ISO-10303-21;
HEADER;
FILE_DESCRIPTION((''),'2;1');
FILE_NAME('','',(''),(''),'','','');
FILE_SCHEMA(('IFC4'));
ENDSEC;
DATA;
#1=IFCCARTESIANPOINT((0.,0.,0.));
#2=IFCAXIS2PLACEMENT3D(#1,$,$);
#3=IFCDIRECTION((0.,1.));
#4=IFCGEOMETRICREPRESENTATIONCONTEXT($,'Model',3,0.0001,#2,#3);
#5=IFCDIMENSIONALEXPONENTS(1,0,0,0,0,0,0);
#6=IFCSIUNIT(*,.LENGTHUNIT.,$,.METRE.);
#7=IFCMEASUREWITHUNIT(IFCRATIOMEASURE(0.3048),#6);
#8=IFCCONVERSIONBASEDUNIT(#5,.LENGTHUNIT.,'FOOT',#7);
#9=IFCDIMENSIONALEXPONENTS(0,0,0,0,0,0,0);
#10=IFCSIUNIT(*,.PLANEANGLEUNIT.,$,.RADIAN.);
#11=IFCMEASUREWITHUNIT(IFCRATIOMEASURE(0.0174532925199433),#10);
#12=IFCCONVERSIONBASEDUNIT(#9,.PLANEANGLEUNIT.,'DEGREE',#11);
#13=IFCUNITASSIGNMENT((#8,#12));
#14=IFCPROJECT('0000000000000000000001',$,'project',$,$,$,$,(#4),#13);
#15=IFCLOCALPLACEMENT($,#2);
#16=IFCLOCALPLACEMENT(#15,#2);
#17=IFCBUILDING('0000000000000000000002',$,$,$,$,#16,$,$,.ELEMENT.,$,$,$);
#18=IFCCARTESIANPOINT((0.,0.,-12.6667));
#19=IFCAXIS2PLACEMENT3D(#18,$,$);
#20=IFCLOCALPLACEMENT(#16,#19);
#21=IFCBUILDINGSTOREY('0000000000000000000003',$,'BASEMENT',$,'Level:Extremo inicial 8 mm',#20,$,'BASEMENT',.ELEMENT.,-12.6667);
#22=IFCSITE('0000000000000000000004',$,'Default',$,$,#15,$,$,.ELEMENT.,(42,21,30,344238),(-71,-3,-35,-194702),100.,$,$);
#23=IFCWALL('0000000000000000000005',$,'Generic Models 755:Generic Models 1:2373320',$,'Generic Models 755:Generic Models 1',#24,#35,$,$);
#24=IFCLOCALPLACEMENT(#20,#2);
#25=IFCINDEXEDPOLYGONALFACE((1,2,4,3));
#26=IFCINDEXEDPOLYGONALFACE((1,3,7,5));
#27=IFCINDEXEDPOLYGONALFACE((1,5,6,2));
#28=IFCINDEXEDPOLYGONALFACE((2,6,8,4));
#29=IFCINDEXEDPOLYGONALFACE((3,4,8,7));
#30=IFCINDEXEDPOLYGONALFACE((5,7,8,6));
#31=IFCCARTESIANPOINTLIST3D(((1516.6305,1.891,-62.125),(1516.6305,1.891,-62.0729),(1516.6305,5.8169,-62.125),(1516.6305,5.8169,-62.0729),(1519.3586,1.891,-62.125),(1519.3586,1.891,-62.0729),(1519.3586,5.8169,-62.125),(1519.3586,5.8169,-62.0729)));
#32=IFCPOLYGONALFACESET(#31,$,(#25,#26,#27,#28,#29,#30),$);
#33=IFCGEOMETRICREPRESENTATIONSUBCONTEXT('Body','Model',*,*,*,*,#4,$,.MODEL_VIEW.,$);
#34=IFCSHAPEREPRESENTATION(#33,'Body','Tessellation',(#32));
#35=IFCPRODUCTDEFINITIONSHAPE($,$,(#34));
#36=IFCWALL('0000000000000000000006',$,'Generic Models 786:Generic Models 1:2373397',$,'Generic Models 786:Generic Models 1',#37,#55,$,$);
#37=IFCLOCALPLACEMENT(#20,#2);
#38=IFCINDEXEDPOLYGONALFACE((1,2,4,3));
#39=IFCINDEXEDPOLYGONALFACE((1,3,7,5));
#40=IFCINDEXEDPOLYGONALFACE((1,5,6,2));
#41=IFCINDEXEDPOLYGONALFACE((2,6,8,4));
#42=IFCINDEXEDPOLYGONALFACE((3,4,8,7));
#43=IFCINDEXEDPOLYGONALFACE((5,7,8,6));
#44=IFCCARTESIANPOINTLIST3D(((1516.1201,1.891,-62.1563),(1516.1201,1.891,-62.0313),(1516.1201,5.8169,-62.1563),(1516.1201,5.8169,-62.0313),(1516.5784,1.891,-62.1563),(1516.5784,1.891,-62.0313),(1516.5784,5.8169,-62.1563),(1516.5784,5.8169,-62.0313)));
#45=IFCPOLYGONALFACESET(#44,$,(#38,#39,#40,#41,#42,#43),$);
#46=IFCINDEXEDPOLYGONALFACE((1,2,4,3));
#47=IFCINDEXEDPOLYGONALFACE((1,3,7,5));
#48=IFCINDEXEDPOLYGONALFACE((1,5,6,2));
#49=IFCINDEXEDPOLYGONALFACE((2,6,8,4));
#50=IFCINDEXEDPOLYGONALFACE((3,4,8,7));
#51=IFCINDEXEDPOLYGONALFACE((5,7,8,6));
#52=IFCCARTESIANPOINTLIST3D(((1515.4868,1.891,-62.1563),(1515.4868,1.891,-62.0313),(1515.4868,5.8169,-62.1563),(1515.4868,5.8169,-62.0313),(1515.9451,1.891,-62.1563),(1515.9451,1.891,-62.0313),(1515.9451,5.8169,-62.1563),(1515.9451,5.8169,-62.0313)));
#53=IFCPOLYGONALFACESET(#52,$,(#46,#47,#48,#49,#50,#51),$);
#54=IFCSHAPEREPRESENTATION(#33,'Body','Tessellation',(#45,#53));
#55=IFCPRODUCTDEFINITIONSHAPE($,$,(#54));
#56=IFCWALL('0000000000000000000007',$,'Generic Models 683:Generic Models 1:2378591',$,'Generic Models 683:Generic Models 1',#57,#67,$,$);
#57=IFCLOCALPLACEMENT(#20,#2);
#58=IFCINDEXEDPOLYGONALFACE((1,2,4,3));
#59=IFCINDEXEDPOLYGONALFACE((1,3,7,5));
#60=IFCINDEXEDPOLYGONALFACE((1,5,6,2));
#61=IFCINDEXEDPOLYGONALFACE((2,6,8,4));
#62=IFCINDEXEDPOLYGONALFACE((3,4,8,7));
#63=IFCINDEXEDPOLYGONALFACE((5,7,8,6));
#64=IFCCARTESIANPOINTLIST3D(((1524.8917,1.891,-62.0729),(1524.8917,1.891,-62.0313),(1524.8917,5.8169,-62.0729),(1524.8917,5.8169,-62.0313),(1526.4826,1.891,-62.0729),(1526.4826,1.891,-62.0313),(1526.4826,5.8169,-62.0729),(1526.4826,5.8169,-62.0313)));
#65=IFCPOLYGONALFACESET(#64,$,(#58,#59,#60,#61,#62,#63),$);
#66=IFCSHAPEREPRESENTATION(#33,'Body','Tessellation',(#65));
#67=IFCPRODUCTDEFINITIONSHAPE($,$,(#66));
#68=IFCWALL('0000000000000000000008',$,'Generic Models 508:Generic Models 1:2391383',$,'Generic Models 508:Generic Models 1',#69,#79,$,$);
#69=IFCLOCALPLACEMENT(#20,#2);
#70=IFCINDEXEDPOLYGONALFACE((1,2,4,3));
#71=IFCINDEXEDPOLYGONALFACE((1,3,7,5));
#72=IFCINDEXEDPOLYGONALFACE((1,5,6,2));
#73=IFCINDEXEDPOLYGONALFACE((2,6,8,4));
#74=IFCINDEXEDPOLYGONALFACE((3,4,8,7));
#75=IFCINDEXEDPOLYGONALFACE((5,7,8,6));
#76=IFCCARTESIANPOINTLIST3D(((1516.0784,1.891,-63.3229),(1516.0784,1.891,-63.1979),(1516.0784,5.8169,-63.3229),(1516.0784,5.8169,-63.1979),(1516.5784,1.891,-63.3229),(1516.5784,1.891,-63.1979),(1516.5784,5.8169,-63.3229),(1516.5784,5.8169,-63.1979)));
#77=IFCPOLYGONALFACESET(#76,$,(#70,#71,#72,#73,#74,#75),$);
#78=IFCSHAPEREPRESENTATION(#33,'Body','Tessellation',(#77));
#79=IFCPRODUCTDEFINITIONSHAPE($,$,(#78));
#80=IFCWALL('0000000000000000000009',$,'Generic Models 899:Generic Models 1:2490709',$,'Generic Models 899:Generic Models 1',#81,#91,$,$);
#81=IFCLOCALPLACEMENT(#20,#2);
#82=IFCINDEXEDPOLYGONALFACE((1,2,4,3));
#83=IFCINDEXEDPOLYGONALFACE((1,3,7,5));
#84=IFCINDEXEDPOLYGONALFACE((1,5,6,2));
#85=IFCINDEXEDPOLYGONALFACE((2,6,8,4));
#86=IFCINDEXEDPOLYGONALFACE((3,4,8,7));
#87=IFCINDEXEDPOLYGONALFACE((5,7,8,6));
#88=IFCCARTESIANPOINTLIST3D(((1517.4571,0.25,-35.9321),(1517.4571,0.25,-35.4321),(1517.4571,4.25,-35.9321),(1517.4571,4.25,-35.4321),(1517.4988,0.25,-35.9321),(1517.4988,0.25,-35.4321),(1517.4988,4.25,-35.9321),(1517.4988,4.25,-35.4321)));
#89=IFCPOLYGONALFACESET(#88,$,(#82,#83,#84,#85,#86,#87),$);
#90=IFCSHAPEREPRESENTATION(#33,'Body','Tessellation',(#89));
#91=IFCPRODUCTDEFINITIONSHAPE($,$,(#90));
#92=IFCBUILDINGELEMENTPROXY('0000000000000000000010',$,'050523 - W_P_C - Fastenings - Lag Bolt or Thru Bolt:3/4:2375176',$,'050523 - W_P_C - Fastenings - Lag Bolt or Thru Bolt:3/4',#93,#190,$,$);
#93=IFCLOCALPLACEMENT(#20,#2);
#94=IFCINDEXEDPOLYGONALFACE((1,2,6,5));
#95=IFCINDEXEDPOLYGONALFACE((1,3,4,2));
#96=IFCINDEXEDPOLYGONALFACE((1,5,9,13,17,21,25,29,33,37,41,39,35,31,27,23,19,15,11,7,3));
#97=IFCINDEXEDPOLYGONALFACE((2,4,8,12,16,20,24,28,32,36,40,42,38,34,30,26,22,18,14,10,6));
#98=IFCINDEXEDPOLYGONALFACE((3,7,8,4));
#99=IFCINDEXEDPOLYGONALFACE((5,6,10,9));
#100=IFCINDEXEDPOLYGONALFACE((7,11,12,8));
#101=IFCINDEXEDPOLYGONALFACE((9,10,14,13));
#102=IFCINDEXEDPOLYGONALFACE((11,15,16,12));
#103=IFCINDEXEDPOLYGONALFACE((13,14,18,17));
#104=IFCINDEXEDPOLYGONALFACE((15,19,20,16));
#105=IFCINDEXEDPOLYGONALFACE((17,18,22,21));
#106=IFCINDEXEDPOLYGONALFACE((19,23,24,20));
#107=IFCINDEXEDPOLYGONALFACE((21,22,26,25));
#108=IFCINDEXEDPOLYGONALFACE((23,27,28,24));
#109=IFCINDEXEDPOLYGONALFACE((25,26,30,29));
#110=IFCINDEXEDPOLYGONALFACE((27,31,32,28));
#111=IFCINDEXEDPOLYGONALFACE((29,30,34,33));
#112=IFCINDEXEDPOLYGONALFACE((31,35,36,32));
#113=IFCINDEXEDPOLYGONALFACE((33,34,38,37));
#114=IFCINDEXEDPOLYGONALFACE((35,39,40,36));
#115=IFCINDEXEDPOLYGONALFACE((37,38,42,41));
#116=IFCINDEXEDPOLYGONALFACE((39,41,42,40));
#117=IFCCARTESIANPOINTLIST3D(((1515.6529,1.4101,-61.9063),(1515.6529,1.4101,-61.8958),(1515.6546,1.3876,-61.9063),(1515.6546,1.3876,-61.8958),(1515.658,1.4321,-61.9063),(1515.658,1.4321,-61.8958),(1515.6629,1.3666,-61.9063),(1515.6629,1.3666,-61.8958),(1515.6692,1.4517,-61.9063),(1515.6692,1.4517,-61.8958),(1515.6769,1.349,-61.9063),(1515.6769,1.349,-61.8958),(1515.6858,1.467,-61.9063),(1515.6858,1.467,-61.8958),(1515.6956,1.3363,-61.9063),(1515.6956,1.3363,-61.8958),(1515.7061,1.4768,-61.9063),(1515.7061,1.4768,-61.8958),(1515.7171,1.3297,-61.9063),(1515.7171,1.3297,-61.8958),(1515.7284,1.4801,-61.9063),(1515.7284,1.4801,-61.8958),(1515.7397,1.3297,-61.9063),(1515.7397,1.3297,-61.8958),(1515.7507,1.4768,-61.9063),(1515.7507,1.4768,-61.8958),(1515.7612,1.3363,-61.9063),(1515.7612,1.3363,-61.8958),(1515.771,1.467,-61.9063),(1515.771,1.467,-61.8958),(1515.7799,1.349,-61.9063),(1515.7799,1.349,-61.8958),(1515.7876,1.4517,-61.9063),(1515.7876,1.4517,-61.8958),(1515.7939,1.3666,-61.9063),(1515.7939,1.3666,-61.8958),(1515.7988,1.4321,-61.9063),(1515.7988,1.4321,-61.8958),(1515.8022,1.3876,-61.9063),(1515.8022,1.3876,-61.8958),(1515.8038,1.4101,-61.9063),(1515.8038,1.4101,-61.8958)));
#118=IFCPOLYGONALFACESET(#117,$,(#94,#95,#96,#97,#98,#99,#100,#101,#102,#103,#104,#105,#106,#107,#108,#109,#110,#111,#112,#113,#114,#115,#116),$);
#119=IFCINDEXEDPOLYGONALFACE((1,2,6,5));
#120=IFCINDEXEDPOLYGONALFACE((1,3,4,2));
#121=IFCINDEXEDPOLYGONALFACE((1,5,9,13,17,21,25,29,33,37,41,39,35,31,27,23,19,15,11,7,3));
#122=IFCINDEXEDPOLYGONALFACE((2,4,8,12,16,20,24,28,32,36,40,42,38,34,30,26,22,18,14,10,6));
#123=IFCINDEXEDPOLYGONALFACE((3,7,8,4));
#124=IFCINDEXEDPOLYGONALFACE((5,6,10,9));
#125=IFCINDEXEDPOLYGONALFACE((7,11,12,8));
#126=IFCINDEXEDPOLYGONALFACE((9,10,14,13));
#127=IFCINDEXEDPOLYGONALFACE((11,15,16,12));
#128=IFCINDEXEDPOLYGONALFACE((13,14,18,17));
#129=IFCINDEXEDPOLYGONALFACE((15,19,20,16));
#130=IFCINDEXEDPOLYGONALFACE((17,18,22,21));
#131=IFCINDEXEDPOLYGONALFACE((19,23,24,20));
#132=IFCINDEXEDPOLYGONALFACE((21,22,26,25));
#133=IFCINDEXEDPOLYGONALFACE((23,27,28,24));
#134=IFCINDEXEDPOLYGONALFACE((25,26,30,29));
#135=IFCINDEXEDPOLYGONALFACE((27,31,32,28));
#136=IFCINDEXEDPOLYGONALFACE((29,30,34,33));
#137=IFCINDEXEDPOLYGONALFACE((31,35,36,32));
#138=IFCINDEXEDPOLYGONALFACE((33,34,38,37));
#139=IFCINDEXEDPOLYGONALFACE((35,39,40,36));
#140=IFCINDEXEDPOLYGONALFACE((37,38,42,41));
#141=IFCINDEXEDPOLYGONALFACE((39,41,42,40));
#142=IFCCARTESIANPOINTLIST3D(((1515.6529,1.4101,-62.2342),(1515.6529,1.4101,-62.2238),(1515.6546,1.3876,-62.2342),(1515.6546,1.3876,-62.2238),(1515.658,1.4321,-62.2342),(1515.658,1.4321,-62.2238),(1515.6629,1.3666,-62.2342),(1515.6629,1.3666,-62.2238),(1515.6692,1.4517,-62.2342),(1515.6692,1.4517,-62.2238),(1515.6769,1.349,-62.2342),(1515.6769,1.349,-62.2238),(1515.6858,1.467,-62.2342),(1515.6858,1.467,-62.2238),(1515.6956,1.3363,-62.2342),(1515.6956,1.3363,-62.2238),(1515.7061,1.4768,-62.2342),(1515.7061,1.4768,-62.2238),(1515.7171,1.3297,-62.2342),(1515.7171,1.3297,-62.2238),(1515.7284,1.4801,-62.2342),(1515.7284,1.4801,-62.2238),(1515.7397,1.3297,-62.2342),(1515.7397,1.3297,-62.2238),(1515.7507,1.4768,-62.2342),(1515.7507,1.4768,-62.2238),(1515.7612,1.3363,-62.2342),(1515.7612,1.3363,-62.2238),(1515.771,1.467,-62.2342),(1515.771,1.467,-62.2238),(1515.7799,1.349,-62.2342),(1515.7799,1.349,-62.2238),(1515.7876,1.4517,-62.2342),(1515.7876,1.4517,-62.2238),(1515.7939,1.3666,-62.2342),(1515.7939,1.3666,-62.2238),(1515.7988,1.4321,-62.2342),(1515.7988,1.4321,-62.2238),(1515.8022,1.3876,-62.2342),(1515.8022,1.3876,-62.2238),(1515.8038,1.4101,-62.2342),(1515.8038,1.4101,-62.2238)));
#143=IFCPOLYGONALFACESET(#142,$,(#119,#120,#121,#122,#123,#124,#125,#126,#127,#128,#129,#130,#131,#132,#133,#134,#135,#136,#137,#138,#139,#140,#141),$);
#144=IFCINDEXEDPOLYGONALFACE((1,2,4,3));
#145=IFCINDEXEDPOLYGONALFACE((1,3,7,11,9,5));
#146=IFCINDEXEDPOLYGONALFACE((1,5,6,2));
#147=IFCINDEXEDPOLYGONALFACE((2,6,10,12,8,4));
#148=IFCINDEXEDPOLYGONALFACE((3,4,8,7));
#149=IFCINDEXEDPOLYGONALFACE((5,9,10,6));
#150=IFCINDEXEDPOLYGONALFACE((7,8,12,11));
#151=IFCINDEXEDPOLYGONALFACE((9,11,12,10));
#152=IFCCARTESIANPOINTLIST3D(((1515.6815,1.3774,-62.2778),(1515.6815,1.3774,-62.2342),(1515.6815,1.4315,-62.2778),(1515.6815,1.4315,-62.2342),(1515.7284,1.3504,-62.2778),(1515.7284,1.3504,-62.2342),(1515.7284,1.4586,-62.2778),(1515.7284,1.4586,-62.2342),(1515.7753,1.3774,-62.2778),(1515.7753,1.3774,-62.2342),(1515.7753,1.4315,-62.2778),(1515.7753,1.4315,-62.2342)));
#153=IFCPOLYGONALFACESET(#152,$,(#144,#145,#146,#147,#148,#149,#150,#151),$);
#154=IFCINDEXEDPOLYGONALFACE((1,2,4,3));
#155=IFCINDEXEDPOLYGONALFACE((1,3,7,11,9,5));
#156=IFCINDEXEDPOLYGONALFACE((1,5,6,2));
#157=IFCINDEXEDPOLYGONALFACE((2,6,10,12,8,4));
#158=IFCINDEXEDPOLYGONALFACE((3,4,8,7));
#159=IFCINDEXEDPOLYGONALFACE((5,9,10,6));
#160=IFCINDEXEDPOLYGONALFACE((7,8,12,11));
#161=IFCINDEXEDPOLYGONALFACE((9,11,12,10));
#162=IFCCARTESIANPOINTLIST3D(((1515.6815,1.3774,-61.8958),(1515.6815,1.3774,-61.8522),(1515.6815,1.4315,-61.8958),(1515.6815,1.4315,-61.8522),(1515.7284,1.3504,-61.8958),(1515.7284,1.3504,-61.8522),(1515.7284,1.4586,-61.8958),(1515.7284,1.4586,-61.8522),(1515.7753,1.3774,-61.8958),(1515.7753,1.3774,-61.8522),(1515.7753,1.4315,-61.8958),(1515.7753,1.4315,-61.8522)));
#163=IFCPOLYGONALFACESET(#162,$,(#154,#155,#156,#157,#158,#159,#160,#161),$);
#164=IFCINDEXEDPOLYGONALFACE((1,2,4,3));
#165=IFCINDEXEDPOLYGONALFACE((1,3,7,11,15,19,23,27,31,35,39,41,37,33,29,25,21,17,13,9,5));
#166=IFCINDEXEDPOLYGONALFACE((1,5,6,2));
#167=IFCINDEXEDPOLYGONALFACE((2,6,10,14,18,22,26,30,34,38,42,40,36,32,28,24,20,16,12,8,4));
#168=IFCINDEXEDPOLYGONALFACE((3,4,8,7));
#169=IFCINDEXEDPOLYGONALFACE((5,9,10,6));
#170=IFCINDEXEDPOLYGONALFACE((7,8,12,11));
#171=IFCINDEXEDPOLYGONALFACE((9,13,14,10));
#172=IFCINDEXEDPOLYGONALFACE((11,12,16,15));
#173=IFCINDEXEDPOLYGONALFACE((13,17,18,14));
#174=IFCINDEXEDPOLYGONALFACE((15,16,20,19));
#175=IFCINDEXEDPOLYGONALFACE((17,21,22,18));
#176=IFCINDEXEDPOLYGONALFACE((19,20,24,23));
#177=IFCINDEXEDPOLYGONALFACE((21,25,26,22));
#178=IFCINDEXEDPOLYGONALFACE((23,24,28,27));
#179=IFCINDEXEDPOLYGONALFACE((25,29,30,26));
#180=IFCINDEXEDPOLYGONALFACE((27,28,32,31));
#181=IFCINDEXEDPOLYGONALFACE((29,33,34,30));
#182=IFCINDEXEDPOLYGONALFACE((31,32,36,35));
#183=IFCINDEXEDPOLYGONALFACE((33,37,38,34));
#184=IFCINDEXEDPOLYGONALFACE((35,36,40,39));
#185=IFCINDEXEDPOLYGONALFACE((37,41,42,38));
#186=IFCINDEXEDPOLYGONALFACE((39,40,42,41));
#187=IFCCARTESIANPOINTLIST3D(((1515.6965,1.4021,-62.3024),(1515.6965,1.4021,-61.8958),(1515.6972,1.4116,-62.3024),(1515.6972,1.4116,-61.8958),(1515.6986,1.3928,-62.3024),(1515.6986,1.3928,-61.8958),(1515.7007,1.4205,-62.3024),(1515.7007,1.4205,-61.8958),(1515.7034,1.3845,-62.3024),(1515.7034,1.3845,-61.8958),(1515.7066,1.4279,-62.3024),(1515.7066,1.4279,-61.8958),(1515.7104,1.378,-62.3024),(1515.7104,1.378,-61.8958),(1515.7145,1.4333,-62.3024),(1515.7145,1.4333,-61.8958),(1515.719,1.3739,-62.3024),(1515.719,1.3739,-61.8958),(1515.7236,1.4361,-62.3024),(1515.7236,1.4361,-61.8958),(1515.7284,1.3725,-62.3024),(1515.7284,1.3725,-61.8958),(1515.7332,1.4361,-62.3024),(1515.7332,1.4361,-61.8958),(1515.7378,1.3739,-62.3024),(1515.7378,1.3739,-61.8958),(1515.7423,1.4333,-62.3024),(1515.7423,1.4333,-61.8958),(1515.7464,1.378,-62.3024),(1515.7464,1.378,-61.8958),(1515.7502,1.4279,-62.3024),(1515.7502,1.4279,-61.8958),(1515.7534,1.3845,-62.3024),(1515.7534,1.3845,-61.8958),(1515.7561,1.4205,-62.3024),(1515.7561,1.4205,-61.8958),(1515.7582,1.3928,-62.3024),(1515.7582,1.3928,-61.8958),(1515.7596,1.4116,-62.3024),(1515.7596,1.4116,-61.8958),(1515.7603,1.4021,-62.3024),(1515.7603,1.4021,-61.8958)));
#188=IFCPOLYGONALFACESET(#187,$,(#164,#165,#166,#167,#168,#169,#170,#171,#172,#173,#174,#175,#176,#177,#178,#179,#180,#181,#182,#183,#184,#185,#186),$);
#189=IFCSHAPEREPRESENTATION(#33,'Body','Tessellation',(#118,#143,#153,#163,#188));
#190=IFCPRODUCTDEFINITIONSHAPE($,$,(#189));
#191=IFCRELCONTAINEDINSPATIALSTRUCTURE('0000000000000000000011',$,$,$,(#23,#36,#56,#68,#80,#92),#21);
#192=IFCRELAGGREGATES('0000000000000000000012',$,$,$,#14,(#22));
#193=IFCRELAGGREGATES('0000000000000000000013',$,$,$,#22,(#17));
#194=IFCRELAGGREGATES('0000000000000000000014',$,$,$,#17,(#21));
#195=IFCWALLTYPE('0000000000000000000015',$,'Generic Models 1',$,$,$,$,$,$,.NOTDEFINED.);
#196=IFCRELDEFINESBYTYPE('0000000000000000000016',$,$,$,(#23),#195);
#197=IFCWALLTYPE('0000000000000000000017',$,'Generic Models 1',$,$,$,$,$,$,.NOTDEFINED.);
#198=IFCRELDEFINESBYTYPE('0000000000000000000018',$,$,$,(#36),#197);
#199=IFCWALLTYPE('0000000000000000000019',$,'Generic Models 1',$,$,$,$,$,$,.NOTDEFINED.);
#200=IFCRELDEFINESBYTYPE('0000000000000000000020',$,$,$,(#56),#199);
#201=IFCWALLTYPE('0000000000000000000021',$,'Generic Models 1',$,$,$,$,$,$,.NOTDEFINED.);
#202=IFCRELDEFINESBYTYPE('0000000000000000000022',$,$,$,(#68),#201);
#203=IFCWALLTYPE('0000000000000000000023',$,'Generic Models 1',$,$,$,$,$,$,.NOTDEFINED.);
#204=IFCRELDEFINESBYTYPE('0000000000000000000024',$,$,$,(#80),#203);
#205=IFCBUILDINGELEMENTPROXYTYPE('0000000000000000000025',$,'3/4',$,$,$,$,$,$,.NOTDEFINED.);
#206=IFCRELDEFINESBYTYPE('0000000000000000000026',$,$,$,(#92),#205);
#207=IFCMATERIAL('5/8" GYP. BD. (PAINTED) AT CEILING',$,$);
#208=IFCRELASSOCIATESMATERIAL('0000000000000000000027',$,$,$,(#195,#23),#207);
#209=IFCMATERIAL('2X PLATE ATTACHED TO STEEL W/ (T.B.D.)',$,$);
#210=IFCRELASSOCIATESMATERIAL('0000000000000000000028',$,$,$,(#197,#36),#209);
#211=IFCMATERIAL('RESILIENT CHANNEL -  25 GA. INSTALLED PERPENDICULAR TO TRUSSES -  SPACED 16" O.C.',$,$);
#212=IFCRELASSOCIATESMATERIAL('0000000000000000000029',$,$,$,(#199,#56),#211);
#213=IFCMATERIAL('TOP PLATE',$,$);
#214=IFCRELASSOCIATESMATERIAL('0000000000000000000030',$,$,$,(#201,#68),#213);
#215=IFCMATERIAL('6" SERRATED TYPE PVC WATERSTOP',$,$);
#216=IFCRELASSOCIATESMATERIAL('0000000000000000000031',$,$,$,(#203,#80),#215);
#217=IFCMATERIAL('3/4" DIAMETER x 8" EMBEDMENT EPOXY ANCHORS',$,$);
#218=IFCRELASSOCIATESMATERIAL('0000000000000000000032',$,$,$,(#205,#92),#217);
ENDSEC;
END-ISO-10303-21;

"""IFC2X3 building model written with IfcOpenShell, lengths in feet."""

from ifc_helpers import new_model, entity, si_unit, converted_unit, direction, frame, frame_2d, origin, place, context, subcontext, project, spatial, polyline, rectangle, circle, outline, extrude, source, transform, mapped, material, type_object, type_shapes, element, save


model = new_model("IFC2X3")

# Units and contexts
model_context = context("Model", 3, precision=0.0001, world=origin(), true_north=direction((0.0, 1.0)))
body_context = subcontext(model_context, "Body", "Model", "MODEL_VIEW")
ifc_project = project(units=[converted_unit("LENGTHUNIT", "FOOT", entity("IfcRatioMeasure", 0.3048), si_unit("LENGTHUNIT", "METRE"), dimensions=[1, 0, 0, 0, 0, 0, 0]), converted_unit("PLANEANGLEUNIT", "DEGREE", entity("IfcRatioMeasure", 0.0174532925199433), si_unit("PLANEANGLEUNIT", "RADIAN"), dimensions=[0, 0, 0, 0, 0, 0, 0])], contexts=[model_context])

# Site, building, storey
site_placement = place(None, origin())
site = spatial("IfcSite", under=ifc_project, at=site_placement, Name="Default", CompositionType="ELEMENT", RefLatitude=(42, 21, 30, 344238), RefLongitude=(-71, -3, -35, -194702), RefElevation=100.0)
building_placement = place(site_placement, origin())
building = spatial("IfcBuilding", under=site, at=building_placement, CompositionType="ELEMENT")
storey_placement = place(building_placement, frame((0.0, 0.0, -12.6667)))
storey = spatial("IfcBuildingStorey", under=building, at=storey_placement, Name="BASEMENT", ObjectType="Level:Extremo inicial 8 mm", LongName="BASEMENT", CompositionType="ELEMENT", Elevation=-12.6667)

# Walls
ifc_material_1 = material(Name="5/8\" GYP. BD. (PAINTED) AT CEILING")
ifc_material_2 = material(Name="TOP PLATE")
wall_type_1 = type_object("IfcWallType", Name="Generic Models 1", PredefinedType="NOTDEFINED", material=ifc_material_1)
wall_1_placement = place(storey_placement, frame((1516.6305, 1.891, -62.125), z_axis=(0.0, 0.0, 1.0), x_axis=(0.0, 1.0, 0.0)))
element("IfcWall", 1, at=wall_1_placement, inside=storey, type_object=wall_type_1, material=ifc_material_1, Name="Generic Models 755:Generic Models 1:2373320", ObjectType="Generic Models 755:Generic Models 1", context=body_context, shape_type="SweptSolid", body=[
    extrude(rectangle(XDim=3.9258, YDim=2.7281, at=frame_2d((0.0, 0.0), x_axis=(1.0, 0.0))), frame((1.9629, -1.364, 0.0)), (0.0, 0.0, 1.0), 0.0521),
])
ifc_material_3 = material(Name="2X PLATE ATTACHED TO STEEL W/ (T.B.D.)")
wall_type_2 = type_object("IfcWallType", Name="Generic Models 1", PredefinedType="NOTDEFINED", material=ifc_material_3)
wall_2_placement = place(storey_placement, frame((1515.4868, 1.891, -62.1563), z_axis=(0.0, 0.0, 1.0), x_axis=(0.0, 1.0, 0.0)))
element("IfcWall", 2, at=wall_2_placement, inside=storey, type_object=wall_type_2, material=ifc_material_3, Name="Generic Models 786:Generic Models 1:2373397", ObjectType="Generic Models 786:Generic Models 1", context=body_context, shape_type="SweptSolid", body=[
    extrude(rectangle(XDim=3.9258, YDim=0.4583, at=frame_2d((0.0, 0.0), x_axis=(1.0, 0.0))), frame((1.9629, -0.8625, 0.0)), (0.0, 0.0, 1.0), 0.125),
    extrude(rectangle(XDim=3.9258, YDim=0.4583, at=frame_2d((0.0, 0.0), x_axis=(1.0, 0.0))), frame((1.9629, -0.2292, 0.0)), (0.0, 0.0, 1.0), 0.125),
])
ifc_material_4 = material(Name="RESILIENT CHANNEL -  25 GA. INSTALLED PERPENDICULAR TO TRUSSES -  SPACED 16\" O.C.")
wall_type_3 = type_object("IfcWallType", Name="Generic Models 1", PredefinedType="NOTDEFINED", material=ifc_material_4)
wall_3_placement = place(storey_placement, frame((1524.8917, 1.891, -62.0729), z_axis=(0.0, 0.0, 1.0), x_axis=(0.0, 1.0, 0.0)))
element("IfcWall", 3, at=wall_3_placement, inside=storey, type_object=wall_type_3, material=ifc_material_4, Name="Generic Models 683:Generic Models 1:2378591", ObjectType="Generic Models 683:Generic Models 1", context=body_context, shape_type="SweptSolid", body=[
    extrude(rectangle(XDim=3.9258, YDim=1.5909, at=frame_2d((0.0, 0.0), x_axis=(1.0, 0.0))), frame((1.9629, -0.7955, 0.0)), (0.0, 0.0, 1.0), 0.0417),
])
wall_type_4 = type_object("IfcWallType", Name="Generic Models 1", PredefinedType="NOTDEFINED", material=ifc_material_2)
wall_4_placement = place(storey_placement, frame((1516.0784, 1.891, -63.3229), z_axis=(0.0, 0.0, 1.0), x_axis=(0.0, 1.0, 0.0)))
element("IfcWall", 4, at=wall_4_placement, inside=storey, type_object=wall_type_4, material=ifc_material_2, Name="Generic Models 508:Generic Models 1:2391383", ObjectType="Generic Models 508:Generic Models 1", context=body_context, shape_type="SweptSolid", body=[
    extrude(rectangle(XDim=3.9258, YDim=0.5, at=frame_2d((0.0, 0.0), x_axis=(1.0, 0.0))), frame((1.9629, -0.25, 0.0)), (0.0, 0.0, 1.0), 0.125),
])
ifc_material_5 = material(Name="6\" SERRATED TYPE PVC WATERSTOP")
wall_type_5 = type_object("IfcWallType", Name="Generic Models 1", PredefinedType="NOTDEFINED", material=ifc_material_5)
wall_5_placement = place(storey_placement, frame((1517.4571, 0.25, -35.9321), z_axis=(0.0, 0.0, 1.0), x_axis=(0.0, 1.0, 0.0)))
element("IfcWall", 5, at=wall_5_placement, inside=storey, type_object=wall_type_5, material=ifc_material_5, Name="Generic Models 899:Generic Models 1:2490709", ObjectType="Generic Models 899:Generic Models 1", context=body_context, shape_type="SweptSolid", body=[
    extrude(rectangle(XDim=4.0, YDim=0.0417, at=frame_2d((0.0, 0.0), x_axis=(1.0, 0.0))), frame((2.0, -0.0208, 0.0)), (0.0, 0.0, 1.0), 0.5),
])

# Building element proxy
ifc_material_6 = material(Name="3/4\" DIAMETER x 8\" EMBEDMENT EPOXY ANCHORS")
building_element_proxy_type_1 = type_object("IfcBuildingElementProxyType", Name="3/4", PredefinedType="NOTDEFINED", material=ifc_material_6)
shared_shape_1 = source(origin(), body_context, "Body", "SweptSolid", [
    extrude(circle(Radius=0.0757, at=frame_2d((0.0, 0.0), x_axis=(1.0, 0.0))), frame((0.0, 0.0, 0.0), z_axis=(0.0, 0.0, 1.0), x_axis=(0.0, -1.0, 0.0)), (0.0, 0.0, 1.0), 0.0104),
    extrude(circle(Radius=0.0757, at=frame_2d((0.0, 0.0), x_axis=(1.0, 0.0))), frame((0.0, 0.0, -0.3279), z_axis=(0.0, 0.0, 1.0), x_axis=(0.0, -1.0, 0.0)), (0.0, 0.0, 1.0), 0.0104),
    extrude(outline(polyline([(-0.0271, -0.0469), (0.0271, -0.0469), (0.0541, 0.0), (0.0271, 0.0469), (-0.0271, 0.0469), (-0.0541, 0.0), (-0.0271, -0.0469)])), frame((0.0, 0.0, -0.3716), z_axis=(0.0, 0.0, 1.0), x_axis=(0.866025, -0.5, 0.0)), (0.0, 0.0, 1.0), 0.0437),
    extrude(outline(polyline([(-0.0271, -0.0469), (0.0271, -0.0469), (0.0541, 0.0), (0.0271, 0.0469), (-0.0271, 0.0469), (-0.0541, 0.0), (-0.0271, -0.0469)])), frame((0.0, 0.0, 0.0104), z_axis=(0.0, 0.0, 1.0), x_axis=(0.0, -1.0, 0.0)), (0.0, 0.0, 1.0), 0.0437),
    extrude(circle(Radius=0.032, at=frame_2d((0.0, 0.0), x_axis=(1.0, 0.0))), frame((0.0, 0.0, -0.3962), z_axis=(0.0, 0.0, 1.0), x_axis=(0.0, 1.0, 0.0)), (0.0, 0.0, 1.0), 0.4066),
])
type_shapes(building_element_proxy_type_1, [shared_shape_1])
proxy_1_placement = place(storey_placement, frame((1515.7284, 1.4045, -61.9063), z_axis=(0.0, 0.0, 1.0), x_axis=(-1.0, 0.0, 0.0)))
element("IfcBuildingElementProxy", 6, at=proxy_1_placement, inside=storey, type_object=building_element_proxy_type_1, material=ifc_material_6, Name="050523 - W_P_C - Fastenings - Lag Bolt or Thru Bolt:3/4:2375176", ObjectType="050523 - W_P_C - Fastenings - Lag Bolt or Thru Bolt:3/4", context=body_context, shape_type="MappedRepresentation", body=[
    mapped(shared_shape_1, transform((0.0, 0.0, 0.0), scale=1.0)),
])

save(model, "model.ifc")
